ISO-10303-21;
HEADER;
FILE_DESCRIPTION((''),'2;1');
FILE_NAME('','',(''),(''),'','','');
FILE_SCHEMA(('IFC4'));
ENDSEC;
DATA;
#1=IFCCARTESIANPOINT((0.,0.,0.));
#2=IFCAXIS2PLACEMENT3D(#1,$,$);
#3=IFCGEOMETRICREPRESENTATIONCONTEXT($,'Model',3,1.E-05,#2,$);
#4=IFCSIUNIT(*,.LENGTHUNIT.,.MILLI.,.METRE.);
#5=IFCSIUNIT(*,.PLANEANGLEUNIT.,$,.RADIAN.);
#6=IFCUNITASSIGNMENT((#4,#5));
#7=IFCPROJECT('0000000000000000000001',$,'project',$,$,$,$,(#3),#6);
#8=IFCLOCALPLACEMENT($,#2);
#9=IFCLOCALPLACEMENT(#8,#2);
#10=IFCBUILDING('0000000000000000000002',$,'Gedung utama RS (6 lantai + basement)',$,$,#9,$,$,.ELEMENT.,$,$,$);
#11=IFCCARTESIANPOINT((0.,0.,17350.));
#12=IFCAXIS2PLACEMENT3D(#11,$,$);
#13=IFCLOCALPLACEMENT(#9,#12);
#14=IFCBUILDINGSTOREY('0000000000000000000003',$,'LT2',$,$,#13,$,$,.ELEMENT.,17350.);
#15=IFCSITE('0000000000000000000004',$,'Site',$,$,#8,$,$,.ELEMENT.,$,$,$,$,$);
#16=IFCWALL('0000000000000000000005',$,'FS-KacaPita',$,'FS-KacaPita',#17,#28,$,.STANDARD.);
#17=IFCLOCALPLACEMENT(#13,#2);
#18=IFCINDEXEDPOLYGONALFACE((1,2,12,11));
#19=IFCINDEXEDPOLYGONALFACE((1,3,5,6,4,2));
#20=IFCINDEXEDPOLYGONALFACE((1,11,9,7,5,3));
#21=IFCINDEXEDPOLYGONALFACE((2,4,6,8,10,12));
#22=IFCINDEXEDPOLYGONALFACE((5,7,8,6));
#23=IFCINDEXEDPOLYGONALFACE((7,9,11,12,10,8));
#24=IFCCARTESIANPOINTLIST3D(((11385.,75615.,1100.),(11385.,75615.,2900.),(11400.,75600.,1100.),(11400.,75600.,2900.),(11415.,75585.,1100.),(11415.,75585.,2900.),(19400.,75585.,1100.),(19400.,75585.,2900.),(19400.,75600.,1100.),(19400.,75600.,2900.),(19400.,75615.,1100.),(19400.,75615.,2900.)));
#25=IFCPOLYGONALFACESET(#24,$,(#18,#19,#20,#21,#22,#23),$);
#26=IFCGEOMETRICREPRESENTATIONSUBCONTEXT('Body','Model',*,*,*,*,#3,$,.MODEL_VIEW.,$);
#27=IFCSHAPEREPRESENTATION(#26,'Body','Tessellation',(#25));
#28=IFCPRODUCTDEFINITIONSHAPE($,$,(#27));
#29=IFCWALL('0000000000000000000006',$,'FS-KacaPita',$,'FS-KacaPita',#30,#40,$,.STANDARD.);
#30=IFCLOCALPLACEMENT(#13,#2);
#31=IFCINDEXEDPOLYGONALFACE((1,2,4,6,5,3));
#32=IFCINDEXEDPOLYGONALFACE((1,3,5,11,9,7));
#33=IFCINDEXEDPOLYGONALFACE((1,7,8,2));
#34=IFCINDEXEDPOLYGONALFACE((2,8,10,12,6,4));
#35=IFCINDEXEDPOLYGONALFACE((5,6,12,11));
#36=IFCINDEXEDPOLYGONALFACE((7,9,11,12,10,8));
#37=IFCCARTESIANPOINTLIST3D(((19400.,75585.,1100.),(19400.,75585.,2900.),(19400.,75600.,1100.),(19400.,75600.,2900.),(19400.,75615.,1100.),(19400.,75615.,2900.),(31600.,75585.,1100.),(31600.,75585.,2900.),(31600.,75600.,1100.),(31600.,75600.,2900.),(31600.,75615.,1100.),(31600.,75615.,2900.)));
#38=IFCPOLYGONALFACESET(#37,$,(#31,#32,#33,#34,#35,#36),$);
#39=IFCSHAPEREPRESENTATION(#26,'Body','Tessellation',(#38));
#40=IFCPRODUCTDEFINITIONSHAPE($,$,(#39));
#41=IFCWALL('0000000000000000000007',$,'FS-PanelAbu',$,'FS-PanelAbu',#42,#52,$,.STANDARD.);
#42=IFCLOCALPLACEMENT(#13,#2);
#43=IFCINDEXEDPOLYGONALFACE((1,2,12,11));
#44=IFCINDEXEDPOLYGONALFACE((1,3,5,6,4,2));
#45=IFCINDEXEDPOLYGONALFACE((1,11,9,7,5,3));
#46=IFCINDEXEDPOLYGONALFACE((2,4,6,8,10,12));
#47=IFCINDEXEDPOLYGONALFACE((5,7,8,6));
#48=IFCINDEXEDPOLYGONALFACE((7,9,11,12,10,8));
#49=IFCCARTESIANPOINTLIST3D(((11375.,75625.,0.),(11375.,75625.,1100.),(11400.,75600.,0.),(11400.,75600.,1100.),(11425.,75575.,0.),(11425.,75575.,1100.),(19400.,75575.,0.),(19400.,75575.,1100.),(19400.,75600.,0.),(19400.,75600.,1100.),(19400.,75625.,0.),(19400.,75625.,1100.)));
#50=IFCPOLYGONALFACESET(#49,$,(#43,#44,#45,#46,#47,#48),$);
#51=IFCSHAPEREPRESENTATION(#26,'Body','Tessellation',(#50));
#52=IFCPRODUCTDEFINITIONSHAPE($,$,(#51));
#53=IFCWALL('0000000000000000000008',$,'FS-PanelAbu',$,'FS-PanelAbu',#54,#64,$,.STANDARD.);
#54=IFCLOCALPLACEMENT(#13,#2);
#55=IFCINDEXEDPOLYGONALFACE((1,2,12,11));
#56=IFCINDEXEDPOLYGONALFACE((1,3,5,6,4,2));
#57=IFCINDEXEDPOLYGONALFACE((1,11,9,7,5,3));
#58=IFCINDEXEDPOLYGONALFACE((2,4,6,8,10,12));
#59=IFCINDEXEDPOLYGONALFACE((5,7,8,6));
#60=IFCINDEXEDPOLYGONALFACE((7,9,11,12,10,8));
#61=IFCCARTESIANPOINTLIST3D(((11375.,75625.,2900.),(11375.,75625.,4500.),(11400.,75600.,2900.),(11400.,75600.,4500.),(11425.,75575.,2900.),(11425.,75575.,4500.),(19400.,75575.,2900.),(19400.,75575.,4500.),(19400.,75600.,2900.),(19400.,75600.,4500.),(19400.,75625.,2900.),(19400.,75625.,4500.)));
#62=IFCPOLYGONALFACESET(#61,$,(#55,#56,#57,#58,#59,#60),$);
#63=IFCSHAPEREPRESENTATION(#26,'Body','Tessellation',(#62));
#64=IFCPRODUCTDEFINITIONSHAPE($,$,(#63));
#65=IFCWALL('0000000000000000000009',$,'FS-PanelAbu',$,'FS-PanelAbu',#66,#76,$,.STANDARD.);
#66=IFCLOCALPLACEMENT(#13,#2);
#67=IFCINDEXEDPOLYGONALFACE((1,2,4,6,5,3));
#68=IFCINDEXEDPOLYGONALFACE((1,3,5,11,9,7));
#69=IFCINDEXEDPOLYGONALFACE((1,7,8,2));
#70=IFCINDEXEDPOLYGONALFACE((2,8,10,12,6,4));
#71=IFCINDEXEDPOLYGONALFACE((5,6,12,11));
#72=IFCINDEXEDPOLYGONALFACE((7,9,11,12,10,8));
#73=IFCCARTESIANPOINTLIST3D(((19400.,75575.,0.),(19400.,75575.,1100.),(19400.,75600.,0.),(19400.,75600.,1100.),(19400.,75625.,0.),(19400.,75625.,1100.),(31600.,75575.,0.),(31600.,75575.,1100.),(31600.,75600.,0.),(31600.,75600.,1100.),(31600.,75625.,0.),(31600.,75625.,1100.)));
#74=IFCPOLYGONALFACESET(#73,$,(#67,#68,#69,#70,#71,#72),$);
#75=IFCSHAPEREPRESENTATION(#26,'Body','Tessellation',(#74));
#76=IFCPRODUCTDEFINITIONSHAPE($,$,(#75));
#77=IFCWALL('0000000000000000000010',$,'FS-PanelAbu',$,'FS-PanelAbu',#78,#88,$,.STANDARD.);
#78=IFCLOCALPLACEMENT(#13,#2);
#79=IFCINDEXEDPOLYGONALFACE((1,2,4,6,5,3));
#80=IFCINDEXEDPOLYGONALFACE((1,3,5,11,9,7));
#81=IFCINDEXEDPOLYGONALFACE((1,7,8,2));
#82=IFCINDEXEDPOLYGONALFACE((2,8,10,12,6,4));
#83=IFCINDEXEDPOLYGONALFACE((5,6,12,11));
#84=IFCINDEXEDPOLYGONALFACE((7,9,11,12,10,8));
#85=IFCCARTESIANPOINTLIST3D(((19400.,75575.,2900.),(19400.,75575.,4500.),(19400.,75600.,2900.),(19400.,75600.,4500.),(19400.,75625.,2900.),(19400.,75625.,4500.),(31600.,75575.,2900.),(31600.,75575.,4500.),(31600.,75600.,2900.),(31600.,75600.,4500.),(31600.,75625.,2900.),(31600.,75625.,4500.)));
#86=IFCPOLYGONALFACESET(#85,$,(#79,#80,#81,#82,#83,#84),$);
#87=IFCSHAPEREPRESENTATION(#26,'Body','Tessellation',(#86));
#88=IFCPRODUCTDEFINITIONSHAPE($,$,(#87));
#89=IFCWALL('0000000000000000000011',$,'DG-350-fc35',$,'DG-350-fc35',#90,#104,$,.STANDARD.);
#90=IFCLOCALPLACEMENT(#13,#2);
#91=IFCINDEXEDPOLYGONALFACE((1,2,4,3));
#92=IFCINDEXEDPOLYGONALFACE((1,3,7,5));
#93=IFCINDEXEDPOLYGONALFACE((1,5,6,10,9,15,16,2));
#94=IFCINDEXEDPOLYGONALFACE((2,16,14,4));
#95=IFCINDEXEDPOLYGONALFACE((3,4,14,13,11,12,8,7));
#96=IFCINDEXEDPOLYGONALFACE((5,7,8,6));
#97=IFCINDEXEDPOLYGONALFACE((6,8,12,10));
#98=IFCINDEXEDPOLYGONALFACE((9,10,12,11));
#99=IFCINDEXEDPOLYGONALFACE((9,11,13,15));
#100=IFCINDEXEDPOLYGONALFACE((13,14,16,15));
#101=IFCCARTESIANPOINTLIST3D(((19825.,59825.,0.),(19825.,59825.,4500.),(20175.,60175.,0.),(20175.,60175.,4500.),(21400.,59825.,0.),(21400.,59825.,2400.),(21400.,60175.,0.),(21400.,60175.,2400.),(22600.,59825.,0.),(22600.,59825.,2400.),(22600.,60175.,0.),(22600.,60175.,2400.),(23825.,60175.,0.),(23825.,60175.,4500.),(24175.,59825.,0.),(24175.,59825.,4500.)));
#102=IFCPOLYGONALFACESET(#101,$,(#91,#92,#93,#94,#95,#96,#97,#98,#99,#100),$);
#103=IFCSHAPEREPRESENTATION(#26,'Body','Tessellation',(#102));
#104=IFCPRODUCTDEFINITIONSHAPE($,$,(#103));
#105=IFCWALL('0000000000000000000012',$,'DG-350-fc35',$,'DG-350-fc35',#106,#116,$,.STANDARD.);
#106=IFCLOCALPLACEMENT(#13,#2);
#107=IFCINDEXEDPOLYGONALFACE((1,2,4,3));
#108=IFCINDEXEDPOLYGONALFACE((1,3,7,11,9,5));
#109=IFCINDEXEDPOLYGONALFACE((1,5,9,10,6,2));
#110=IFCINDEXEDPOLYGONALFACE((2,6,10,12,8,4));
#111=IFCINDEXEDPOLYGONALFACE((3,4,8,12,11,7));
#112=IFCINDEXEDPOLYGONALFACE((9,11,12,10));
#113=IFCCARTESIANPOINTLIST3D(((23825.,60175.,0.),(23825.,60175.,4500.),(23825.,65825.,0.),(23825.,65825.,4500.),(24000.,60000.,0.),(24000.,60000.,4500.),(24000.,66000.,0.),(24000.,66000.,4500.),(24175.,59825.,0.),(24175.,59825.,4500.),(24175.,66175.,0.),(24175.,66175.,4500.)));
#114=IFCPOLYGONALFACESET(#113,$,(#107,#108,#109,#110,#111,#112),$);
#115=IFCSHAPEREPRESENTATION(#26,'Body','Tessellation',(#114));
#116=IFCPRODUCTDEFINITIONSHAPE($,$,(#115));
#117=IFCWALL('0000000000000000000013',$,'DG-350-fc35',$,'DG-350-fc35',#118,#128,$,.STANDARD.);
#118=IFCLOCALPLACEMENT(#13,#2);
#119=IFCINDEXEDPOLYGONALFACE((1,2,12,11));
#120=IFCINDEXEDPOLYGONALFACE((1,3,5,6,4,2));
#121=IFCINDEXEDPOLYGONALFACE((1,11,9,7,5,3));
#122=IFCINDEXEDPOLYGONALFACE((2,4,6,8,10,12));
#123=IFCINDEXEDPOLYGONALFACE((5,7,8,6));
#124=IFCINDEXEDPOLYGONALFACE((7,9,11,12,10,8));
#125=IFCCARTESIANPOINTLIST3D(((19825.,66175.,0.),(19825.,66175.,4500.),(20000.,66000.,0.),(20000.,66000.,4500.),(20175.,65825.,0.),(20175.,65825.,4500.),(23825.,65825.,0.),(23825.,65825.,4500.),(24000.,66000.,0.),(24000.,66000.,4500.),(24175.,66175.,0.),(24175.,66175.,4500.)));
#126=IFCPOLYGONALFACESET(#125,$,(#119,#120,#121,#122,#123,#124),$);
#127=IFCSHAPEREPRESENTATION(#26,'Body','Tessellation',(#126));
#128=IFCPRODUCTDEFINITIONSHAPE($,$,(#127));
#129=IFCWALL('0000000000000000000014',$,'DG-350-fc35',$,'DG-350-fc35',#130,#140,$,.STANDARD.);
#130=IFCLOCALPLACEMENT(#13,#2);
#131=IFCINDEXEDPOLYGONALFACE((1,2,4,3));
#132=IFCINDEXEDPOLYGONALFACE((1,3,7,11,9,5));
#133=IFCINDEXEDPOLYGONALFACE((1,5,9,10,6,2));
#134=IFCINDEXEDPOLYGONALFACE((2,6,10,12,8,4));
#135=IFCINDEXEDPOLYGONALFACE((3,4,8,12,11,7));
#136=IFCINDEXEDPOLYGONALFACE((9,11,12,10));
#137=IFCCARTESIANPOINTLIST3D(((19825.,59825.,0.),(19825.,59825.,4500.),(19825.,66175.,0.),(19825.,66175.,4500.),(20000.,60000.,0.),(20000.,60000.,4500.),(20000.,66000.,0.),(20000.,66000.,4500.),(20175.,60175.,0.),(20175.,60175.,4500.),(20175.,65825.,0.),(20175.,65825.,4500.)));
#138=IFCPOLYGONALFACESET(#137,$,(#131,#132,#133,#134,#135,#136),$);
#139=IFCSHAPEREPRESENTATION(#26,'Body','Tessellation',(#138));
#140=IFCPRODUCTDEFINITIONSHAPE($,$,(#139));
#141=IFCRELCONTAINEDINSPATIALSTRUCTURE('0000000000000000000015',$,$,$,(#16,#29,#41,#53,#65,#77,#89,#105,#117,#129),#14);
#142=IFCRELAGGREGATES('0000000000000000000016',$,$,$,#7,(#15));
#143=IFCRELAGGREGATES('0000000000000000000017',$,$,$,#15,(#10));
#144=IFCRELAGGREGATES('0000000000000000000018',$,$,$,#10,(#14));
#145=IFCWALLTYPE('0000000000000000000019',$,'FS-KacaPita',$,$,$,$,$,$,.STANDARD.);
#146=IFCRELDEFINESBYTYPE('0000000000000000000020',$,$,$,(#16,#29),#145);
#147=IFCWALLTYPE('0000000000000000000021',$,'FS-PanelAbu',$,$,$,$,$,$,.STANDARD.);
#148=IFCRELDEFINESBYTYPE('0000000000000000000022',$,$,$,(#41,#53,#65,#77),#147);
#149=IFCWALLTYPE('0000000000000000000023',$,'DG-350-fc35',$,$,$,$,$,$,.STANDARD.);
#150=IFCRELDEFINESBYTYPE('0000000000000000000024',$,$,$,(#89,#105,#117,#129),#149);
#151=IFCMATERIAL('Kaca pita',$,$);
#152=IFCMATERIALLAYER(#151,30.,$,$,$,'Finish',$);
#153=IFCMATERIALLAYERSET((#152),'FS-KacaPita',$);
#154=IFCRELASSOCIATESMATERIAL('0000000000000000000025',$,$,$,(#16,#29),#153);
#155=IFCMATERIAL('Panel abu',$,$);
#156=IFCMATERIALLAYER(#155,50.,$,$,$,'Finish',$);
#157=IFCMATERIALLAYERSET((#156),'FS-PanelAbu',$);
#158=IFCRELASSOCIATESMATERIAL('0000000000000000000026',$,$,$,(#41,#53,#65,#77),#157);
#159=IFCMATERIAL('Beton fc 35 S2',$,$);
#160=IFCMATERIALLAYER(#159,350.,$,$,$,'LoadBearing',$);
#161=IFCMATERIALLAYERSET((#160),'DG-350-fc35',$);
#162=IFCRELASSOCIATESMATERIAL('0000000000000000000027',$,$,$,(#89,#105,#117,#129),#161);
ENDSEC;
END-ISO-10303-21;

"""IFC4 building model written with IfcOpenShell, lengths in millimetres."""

from ifc_helpers import new_model, si_unit, frame, frame_2d, origin, place, context, subcontext, project, spatial, polyline, rectangle, outline, extrude, material, layer, layer_set, layer_usage, type_object, element, save


model = new_model("IFC4")

# Units and contexts
model_context = context("Model", 3, precision=1e-05, world=origin())
body_context = subcontext(model_context, "Body", "Model", "MODEL_VIEW")
ifc_project = project(units=[si_unit("LENGTHUNIT", "METRE", prefix="MILLI"), si_unit("PLANEANGLEUNIT", "RADIAN")], contexts=[model_context])

# Site, building, storey
site_placement = place(None, origin())
site = spatial("IfcSite", under=ifc_project, at=site_placement, Name="Site", CompositionType="ELEMENT")
building_placement = place(site_placement, origin())
building = spatial("IfcBuilding", under=site, at=building_placement, Name="Gedung utama RS (6 lantai + basement)", CompositionType="ELEMENT")
storey_placement = place(building_placement, frame((0.0, 0.0, 17350.0)))
storey = spatial("IfcBuildingStorey", under=building, at=storey_placement, Name="LT2", CompositionType="ELEMENT", Elevation=17350.0)

# Walls
ifc_material_1 = material(Name="Kaca pita")
ifc_layer_1 = layer(ifc_material_1, 30.0, Category="Finish")
ifc_layer_set_1 = layer_set([ifc_layer_1], Name="FS-KacaPita")
ifc_layer_usage_1 = layer_usage(ifc_layer_set_1, "AXIS2", "NEGATIVE", 15.0)
wall_type_1 = type_object("IfcWallType", Name="FS-KacaPita", PredefinedType="STANDARD")
wall_1_placement = place(storey_placement, frame((11400.0, 75600.0, 1100.0), z_axis=(0.0, 0.0, 1.0), x_axis=(1.0, 0.0, 0.0)))
element("IfcWall", 1, at=wall_1_placement, inside=storey, type_object=wall_type_1, material=ifc_layer_usage_1, Name="FS-KacaPita", ObjectType="FS-KacaPita", PredefinedType="STANDARD", context=body_context, shape_type="SweptSolid", body=[
    extrude(outline(polyline([(15.0, -15.0), (0.0, 0.0), (-15.0, 15.0), (8000.0, 15.0), (8000.0, 0.0), (8000.0, -15.0), (15.0, -15.0)])), origin(), (0.0, 0.0, 1.0), 1800.0),
])
wall_2_placement = place(storey_placement, frame((19400.0, 75600.0, 1100.0), z_axis=(0.0, 0.0, 1.0), x_axis=(1.0, 0.0, 0.0)))
element("IfcWall", 2, at=wall_2_placement, inside=storey, type_object=wall_type_1, material=ifc_layer_usage_1, Name="FS-KacaPita", ObjectType="FS-KacaPita", PredefinedType="STANDARD", context=body_context, shape_type="SweptSolid", body=[
    extrude(outline(polyline([(0.0, -15.0), (0.0, 0.0), (0.0, 15.0), (12200.0, 15.0), (12200.0, 0.0), (12200.0, -15.0), (0.0, -15.0)])), origin(), (0.0, 0.0, 1.0), 1800.0),
])
ifc_material_2 = material(Name="Panel abu")
ifc_layer_2 = layer(ifc_material_2, 50.0, Category="Finish")
ifc_layer_set_2 = layer_set([ifc_layer_2], Name="FS-PanelAbu")
ifc_layer_usage_2 = layer_usage(ifc_layer_set_2, "AXIS2", "NEGATIVE", 25.0)
wall_type_2 = type_object("IfcWallType", Name="FS-PanelAbu", PredefinedType="STANDARD")
wall_3_placement = place(storey_placement, frame((11400.0, 75600.0, 0.0), z_axis=(0.0, 0.0, 1.0), x_axis=(1.0, 0.0, 0.0)))
element("IfcWall", 3, at=wall_3_placement, inside=storey, type_object=wall_type_2, material=ifc_layer_usage_2, Name="FS-PanelAbu", ObjectType="FS-PanelAbu", PredefinedType="STANDARD", context=body_context, shape_type="SweptSolid", body=[
    extrude(outline(polyline([(25.0, -25.0), (0.0, 0.0), (-25.0, 25.0), (8000.0, 25.0), (8000.0, 0.0), (8000.0, -25.0), (25.0, -25.0)])), origin(), (0.0, 0.0, 1.0), 1100.0),
])
wall_4_placement = place(storey_placement, frame((11400.0, 75600.0, 2900.0), z_axis=(0.0, 0.0, 1.0), x_axis=(1.0, 0.0, 0.0)))
element("IfcWall", 4, at=wall_4_placement, inside=storey, type_object=wall_type_2, material=ifc_layer_usage_2, Name="FS-PanelAbu", ObjectType="FS-PanelAbu", PredefinedType="STANDARD", context=body_context, shape_type="SweptSolid", body=[
    extrude(outline(polyline([(25.0, -25.0), (0.0, 0.0), (-25.0, 25.0), (8000.0, 25.0), (8000.0, 0.0), (8000.0, -25.0), (25.0, -25.0)])), origin(), (0.0, 0.0, 1.0), 1600.0),
])
wall_5_placement = place(storey_placement, frame((19400.0, 75600.0, 0.0), z_axis=(0.0, 0.0, 1.0), x_axis=(1.0, 0.0, 0.0)))
element("IfcWall", 5, at=wall_5_placement, inside=storey, type_object=wall_type_2, material=ifc_layer_usage_2, Name="FS-PanelAbu", ObjectType="FS-PanelAbu", PredefinedType="STANDARD", context=body_context, shape_type="SweptSolid", body=[
    extrude(outline(polyline([(0.0, -25.0), (0.0, 0.0), (0.0, 25.0), (12200.0, 25.0), (12200.0, 0.0), (12200.0, -25.0), (0.0, -25.0)])), origin(), (0.0, 0.0, 1.0), 1100.0),
])
wall_6_placement = place(storey_placement, frame((19400.0, 75600.0, 2900.0), z_axis=(0.0, 0.0, 1.0), x_axis=(1.0, 0.0, 0.0)))
element("IfcWall", 6, at=wall_6_placement, inside=storey, type_object=wall_type_2, material=ifc_layer_usage_2, Name="FS-PanelAbu", ObjectType="FS-PanelAbu", PredefinedType="STANDARD", context=body_context, shape_type="SweptSolid", body=[
    extrude(outline(polyline([(0.0, -25.0), (0.0, 0.0), (0.0, 25.0), (12200.0, 25.0), (12200.0, 0.0), (12200.0, -25.0), (0.0, -25.0)])), origin(), (0.0, 0.0, 1.0), 1600.0),
])

# Wall, opening
ifc_material_3 = material(Name="Beton fc 35 S2")
ifc_layer_3 = layer(ifc_material_3, 350.0, Category="LoadBearing")
ifc_layer_set_3 = layer_set([ifc_layer_3], Name="DG-350-fc35")
ifc_layer_usage_3 = layer_usage(ifc_layer_set_3, "AXIS2", "NEGATIVE", 175.0)
wall_type_3 = type_object("IfcWallType", Name="DG-350-fc35", PredefinedType="STANDARD")
wall_7_placement = place(storey_placement, frame((20000.0, 60000.0, 0.0), z_axis=(0.0, 0.0, 1.0), x_axis=(1.0, 0.0, 0.0)))
wall_7 = element("IfcWall", 7, at=wall_7_placement, inside=storey, type_object=wall_type_3, material=ifc_layer_usage_3, Name="DG-350-fc35", ObjectType="DG-350-fc35", PredefinedType="STANDARD", context=body_context, shape_type="SweptSolid", body=[
    extrude(outline(polyline([(-175.0, -175.0), (0.0, 0.0), (175.0, 175.0), (3825.0, 175.0), (4000.0, 0.0), (4175.0, -175.0), (-175.0, -175.0)])), origin(), (0.0, 0.0, 1.0), 4500.0),
])
opening_1_placement = place(wall_7_placement, frame((1400.0, 0.0, 0.0), z_axis=(0.0, 0.0, 1.0), x_axis=(1.0, 0.0, 0.0)))
element("IfcOpeningElement", 8, at=opening_1_placement, cuts=wall_7, PredefinedType="OPENING", context=body_context, shape_type="SweptSolid", body=[
    extrude(rectangle(XDim=1200.0, YDim=370.0, at=frame_2d((600.0, 0.0))), origin(), (0.0, 0.0, 1.0), 2400.0),
])

# Walls
wall_8_placement = place(storey_placement, frame((24000.0, 60000.0, 0.0), z_axis=(0.0, 0.0, 1.0), x_axis=(0.0, 1.0, 0.0)))
element("IfcWall", 9, at=wall_8_placement, inside=storey, type_object=wall_type_3, material=ifc_layer_usage_3, Name="DG-350-fc35", ObjectType="DG-350-fc35", PredefinedType="STANDARD", context=body_context, shape_type="SweptSolid", body=[
    extrude(outline(polyline([(-175.0, -175.0), (0.0, 0.0), (175.0, 175.0), (5825.0, 175.0), (6000.0, 0.0), (6175.0, -175.0), (-175.0, -175.0)])), origin(), (0.0, 0.0, 1.0), 4500.0),
])
wall_9_placement = place(storey_placement, frame((24000.0, 66000.0, 0.0), z_axis=(0.0, 0.0, 1.0), x_axis=(-1.0, 0.0, 0.0)))
element("IfcWall", 10, at=wall_9_placement, inside=storey, type_object=wall_type_3, material=ifc_layer_usage_3, Name="DG-350-fc35", ObjectType="DG-350-fc35", PredefinedType="STANDARD", context=body_context, shape_type="SweptSolid", body=[
    extrude(outline(polyline([(-175.0, -175.0), (0.0, 0.0), (175.0, 175.0), (3825.0, 175.0), (4000.0, 0.0), (4175.0, -175.0), (-175.0, -175.0)])), origin(), (0.0, 0.0, 1.0), 4500.0),
])
wall_10_placement = place(storey_placement, frame((20000.0, 66000.0, 0.0), z_axis=(0.0, 0.0, 1.0), x_axis=(0.0, -1.0, 0.0)))
element("IfcWall", 11, at=wall_10_placement, inside=storey, type_object=wall_type_3, material=ifc_layer_usage_3, Name="DG-350-fc35", ObjectType="DG-350-fc35", PredefinedType="STANDARD", context=body_context, shape_type="SweptSolid", body=[
    extrude(outline(polyline([(-175.0, -175.0), (0.0, 0.0), (175.0, 175.0), (5825.0, 175.0), (6000.0, 0.0), (6175.0, -175.0), (-175.0, -175.0)])), origin(), (0.0, 0.0, 1.0), 4500.0),
])

save(model, "model.ifc")
